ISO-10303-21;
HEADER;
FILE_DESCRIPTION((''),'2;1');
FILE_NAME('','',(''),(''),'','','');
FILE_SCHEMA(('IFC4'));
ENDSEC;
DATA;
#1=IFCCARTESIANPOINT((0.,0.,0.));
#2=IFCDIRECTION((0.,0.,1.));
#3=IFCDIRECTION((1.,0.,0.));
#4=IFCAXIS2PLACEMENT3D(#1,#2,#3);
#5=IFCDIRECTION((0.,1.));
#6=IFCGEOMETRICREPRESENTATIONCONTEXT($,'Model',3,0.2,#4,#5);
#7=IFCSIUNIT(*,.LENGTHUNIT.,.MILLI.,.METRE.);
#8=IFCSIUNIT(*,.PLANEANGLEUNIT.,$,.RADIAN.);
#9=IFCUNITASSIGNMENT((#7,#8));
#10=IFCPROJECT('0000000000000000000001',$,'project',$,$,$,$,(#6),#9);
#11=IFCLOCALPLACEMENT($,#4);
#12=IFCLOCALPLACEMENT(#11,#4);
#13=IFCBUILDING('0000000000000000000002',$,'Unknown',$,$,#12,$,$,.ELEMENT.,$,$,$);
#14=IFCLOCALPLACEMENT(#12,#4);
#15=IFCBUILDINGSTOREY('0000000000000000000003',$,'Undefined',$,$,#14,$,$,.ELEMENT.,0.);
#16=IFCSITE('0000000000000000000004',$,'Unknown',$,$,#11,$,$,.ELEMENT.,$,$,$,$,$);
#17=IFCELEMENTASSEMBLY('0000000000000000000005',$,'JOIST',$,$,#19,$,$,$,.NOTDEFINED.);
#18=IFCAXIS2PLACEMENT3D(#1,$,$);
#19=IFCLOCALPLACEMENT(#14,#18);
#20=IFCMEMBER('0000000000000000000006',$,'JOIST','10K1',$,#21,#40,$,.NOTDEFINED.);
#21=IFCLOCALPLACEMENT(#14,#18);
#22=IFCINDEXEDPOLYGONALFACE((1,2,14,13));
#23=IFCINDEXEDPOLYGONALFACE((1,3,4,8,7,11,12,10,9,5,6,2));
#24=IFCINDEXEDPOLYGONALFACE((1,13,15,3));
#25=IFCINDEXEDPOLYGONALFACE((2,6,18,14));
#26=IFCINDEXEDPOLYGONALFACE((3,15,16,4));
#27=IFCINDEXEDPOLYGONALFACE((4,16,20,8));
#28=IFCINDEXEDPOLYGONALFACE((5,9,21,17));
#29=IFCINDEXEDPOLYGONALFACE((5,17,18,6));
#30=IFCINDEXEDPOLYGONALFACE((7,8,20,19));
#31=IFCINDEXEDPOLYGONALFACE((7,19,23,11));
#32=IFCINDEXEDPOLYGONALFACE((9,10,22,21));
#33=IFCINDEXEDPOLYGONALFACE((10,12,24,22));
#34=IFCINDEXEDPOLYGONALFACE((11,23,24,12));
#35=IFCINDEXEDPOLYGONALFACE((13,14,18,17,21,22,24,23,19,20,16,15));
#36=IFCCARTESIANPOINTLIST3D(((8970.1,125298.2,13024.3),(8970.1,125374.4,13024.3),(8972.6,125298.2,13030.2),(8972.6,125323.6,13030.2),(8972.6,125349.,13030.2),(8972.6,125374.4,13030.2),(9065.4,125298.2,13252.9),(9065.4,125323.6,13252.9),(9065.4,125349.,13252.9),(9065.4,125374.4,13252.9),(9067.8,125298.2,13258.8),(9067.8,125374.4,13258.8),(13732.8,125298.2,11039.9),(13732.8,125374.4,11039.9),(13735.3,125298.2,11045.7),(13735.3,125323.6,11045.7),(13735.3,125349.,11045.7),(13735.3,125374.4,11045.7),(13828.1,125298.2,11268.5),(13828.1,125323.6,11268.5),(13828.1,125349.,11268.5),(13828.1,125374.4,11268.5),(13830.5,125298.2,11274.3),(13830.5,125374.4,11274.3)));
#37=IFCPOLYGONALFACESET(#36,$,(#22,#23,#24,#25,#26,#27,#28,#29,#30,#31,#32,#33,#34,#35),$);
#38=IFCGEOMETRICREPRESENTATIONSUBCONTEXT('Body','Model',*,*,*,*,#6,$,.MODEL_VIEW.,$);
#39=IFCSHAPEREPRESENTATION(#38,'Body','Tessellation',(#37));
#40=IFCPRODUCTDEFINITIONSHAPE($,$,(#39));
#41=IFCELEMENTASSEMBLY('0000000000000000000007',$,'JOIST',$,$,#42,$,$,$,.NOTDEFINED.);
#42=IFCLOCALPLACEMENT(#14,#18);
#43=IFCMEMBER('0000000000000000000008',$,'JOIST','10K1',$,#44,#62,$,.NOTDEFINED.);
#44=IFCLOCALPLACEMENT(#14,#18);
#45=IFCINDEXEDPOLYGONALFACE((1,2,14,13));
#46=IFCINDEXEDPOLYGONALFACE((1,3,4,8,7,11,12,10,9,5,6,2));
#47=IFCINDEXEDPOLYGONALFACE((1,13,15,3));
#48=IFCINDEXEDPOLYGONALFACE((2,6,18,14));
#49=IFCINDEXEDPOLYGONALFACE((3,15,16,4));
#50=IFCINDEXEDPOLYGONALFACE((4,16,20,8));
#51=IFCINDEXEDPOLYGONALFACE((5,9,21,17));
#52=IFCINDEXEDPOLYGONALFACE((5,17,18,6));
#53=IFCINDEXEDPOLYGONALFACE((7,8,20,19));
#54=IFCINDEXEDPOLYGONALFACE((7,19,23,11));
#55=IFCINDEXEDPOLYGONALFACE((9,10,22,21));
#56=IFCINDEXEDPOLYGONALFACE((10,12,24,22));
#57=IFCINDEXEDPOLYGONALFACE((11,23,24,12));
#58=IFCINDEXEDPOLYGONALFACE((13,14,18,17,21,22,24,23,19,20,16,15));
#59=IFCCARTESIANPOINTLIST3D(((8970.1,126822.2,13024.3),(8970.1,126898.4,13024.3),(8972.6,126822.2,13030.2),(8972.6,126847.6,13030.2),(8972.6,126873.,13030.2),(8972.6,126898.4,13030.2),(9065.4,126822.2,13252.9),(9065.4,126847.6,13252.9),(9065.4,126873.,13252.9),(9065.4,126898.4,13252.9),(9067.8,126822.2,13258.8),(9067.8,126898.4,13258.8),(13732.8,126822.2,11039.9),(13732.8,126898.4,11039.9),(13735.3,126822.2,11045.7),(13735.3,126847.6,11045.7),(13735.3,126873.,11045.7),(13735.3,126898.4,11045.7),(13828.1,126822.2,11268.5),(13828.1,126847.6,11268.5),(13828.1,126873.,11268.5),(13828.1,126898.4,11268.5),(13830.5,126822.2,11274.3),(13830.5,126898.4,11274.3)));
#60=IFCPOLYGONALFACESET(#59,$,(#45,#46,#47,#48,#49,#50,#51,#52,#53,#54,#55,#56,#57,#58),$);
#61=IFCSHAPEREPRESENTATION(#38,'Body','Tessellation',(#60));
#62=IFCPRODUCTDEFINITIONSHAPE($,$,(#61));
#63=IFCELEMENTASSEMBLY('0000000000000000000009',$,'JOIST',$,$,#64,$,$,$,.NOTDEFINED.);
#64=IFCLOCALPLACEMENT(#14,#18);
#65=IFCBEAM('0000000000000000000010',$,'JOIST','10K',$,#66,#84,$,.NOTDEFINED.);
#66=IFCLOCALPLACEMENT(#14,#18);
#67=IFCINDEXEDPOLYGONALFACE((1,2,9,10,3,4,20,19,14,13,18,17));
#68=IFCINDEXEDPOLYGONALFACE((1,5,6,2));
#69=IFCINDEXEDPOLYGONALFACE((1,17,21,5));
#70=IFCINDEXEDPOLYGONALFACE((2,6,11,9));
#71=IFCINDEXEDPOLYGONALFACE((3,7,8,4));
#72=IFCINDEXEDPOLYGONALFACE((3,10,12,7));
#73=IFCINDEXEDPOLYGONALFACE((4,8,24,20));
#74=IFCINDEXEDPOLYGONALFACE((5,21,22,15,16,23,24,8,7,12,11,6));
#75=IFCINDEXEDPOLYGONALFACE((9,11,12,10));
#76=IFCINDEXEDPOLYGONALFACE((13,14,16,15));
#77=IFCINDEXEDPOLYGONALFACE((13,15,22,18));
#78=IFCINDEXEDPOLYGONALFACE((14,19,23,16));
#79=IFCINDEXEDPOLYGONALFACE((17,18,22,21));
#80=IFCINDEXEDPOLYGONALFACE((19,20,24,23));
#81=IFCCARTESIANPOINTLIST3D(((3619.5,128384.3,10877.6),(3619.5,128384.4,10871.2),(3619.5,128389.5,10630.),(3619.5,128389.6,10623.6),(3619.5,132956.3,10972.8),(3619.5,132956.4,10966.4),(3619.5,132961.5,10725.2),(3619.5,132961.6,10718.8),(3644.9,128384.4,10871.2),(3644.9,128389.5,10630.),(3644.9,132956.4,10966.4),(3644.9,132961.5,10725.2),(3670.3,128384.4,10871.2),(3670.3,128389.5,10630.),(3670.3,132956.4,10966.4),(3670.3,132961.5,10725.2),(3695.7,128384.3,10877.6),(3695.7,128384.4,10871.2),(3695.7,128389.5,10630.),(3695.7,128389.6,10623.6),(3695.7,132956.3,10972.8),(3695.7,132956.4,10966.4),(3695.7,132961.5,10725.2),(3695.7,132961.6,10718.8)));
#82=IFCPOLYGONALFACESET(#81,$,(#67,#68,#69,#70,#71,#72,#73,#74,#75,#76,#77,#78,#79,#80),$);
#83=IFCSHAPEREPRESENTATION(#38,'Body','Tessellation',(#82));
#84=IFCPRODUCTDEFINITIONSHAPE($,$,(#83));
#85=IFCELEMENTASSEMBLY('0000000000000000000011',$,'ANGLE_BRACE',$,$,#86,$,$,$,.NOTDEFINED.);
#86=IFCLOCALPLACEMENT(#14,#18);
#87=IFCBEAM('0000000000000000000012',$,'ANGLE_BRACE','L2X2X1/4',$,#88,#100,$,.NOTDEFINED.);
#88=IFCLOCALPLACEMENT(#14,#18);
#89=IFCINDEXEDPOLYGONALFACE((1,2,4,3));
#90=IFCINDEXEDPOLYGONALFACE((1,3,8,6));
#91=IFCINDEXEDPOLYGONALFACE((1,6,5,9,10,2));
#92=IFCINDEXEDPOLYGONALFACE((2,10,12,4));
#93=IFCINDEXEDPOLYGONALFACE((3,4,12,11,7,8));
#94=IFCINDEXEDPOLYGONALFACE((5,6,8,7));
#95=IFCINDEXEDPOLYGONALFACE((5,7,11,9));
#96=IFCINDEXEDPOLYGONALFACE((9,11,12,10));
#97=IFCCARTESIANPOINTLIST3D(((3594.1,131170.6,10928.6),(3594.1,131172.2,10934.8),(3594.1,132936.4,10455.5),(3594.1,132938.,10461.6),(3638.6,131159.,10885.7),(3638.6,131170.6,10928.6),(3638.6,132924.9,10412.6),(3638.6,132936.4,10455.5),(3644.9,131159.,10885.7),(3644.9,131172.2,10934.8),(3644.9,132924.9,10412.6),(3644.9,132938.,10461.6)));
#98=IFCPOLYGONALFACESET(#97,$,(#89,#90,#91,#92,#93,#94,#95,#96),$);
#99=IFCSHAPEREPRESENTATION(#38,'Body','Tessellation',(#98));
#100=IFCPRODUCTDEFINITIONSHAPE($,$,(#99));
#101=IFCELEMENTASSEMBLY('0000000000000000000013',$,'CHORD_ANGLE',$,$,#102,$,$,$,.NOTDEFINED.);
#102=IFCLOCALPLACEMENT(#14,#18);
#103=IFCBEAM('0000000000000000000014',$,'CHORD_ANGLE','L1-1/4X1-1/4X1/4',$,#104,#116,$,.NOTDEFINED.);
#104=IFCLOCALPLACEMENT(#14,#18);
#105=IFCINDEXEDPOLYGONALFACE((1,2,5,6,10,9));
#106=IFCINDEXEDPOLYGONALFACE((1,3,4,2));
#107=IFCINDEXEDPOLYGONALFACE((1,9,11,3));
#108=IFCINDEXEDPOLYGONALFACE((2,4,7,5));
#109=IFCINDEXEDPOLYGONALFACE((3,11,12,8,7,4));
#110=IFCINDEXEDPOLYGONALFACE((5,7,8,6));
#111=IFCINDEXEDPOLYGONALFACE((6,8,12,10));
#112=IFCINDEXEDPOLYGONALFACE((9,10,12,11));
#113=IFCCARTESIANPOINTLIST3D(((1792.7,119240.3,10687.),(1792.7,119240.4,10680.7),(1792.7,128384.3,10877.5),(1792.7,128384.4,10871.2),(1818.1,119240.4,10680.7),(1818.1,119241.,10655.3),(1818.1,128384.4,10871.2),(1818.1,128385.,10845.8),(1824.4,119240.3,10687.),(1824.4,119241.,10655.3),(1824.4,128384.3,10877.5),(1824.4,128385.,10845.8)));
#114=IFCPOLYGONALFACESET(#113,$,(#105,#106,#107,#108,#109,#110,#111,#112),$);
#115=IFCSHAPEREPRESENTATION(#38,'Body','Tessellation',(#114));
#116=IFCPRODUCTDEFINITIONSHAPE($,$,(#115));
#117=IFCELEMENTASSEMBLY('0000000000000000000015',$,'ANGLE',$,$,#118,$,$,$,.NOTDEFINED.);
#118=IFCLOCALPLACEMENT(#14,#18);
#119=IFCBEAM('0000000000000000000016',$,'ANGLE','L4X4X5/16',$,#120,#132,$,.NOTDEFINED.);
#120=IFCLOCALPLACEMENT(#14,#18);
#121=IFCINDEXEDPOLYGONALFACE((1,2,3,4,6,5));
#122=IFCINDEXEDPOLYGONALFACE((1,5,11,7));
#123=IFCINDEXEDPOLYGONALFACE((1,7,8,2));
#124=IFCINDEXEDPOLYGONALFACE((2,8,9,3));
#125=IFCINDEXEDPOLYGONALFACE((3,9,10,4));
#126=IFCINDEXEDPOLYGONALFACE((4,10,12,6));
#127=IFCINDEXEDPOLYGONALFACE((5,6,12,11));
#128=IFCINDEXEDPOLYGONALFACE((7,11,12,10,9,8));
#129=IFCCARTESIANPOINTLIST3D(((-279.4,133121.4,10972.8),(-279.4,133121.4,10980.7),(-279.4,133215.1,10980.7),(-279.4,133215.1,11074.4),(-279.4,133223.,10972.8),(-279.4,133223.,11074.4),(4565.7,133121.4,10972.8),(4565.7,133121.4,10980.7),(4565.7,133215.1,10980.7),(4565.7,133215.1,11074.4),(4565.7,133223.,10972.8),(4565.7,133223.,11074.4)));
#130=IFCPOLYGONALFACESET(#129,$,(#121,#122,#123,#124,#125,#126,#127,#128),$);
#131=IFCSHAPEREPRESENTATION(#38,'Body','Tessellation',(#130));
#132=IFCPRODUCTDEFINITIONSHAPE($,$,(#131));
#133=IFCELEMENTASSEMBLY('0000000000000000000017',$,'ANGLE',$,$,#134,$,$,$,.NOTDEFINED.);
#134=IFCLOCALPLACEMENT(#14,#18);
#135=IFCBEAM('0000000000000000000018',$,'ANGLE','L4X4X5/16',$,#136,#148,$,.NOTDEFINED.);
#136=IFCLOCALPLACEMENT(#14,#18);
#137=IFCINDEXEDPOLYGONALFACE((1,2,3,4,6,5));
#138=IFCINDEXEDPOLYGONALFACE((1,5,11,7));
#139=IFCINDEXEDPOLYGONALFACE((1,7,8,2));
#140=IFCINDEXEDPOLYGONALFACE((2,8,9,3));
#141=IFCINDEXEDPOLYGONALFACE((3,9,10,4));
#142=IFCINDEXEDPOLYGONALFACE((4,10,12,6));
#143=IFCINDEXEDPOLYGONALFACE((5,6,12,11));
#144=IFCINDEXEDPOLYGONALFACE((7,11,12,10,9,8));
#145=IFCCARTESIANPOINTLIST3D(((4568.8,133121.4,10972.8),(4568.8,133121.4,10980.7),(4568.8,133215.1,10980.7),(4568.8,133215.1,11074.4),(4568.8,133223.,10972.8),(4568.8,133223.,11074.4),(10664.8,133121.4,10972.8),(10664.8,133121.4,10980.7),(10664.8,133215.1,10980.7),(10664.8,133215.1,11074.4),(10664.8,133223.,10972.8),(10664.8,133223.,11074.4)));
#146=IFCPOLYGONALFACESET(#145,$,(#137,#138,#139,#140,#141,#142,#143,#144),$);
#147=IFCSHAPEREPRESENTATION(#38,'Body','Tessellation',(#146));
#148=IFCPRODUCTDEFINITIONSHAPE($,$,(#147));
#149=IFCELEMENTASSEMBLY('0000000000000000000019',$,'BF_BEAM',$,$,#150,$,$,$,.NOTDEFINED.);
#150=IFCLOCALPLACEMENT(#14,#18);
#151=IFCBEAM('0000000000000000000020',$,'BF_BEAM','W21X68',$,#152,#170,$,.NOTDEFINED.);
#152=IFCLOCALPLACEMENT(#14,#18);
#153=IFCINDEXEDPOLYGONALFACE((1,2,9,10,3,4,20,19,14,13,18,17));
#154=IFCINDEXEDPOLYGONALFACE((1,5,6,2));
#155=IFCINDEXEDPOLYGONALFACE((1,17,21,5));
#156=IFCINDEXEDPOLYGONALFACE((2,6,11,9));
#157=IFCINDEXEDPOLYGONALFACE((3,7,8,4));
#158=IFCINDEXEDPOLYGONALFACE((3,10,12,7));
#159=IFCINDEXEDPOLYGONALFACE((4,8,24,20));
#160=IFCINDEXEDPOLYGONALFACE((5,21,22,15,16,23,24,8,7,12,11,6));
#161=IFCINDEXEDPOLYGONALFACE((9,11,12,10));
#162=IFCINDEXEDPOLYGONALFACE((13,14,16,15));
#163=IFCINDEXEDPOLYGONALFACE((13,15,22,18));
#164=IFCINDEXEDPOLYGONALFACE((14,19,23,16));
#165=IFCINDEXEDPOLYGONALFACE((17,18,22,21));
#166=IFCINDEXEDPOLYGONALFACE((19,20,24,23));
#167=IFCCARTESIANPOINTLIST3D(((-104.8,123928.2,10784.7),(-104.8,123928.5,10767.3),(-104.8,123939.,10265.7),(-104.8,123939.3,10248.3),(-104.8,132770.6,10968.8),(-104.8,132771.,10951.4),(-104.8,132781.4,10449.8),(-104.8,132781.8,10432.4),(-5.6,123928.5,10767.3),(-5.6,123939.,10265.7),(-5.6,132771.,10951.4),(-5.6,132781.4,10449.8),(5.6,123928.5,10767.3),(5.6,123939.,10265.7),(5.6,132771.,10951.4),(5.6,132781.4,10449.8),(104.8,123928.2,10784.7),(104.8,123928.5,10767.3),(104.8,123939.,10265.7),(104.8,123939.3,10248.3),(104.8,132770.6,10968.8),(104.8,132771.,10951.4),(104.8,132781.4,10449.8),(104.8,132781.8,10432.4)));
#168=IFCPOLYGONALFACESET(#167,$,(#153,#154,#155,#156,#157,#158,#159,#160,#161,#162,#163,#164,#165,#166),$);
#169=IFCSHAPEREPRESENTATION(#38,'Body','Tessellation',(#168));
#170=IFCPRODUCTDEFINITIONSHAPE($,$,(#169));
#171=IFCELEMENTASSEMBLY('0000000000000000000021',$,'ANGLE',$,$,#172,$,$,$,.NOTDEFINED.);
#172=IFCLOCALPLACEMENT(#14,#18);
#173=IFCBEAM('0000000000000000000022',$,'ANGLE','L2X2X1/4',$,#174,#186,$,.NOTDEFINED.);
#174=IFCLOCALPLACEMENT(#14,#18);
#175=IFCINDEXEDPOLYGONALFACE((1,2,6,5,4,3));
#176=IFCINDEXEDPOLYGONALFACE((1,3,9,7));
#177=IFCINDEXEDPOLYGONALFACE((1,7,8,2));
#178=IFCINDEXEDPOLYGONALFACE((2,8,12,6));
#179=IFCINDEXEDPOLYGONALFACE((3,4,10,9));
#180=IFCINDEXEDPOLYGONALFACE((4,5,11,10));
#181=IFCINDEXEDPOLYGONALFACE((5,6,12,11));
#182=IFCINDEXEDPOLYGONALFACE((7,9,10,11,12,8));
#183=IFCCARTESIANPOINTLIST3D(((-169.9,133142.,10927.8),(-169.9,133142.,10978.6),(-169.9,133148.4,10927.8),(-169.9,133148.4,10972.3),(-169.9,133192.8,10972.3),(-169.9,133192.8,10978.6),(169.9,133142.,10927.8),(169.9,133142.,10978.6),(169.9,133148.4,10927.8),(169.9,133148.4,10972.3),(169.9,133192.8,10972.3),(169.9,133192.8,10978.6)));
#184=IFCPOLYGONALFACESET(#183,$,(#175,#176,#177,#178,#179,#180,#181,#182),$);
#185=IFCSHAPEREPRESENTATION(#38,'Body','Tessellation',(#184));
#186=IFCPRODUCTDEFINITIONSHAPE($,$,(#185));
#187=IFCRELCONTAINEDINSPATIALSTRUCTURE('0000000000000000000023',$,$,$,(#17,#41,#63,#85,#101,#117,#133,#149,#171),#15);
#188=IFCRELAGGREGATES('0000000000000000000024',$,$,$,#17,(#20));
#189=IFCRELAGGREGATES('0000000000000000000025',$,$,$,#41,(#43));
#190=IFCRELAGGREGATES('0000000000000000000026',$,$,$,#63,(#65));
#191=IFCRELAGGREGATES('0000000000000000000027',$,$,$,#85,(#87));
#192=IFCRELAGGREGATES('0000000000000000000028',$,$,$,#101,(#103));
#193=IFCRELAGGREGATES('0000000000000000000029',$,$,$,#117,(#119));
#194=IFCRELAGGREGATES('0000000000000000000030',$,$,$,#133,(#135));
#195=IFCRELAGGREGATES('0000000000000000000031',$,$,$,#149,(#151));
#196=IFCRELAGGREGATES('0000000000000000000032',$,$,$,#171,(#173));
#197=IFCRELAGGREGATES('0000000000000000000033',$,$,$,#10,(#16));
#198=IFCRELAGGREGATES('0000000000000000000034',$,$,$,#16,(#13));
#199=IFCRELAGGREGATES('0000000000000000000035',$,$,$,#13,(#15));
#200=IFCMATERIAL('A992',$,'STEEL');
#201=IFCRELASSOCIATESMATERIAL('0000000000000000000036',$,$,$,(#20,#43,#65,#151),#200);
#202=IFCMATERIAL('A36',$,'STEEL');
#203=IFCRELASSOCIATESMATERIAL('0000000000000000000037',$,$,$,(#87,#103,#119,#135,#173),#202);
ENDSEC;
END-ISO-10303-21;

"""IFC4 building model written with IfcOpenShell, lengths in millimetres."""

from ifc_helpers import new_model, si_unit, direction, frame, origin_with_axes, place, context, subcontext, project, spatial, line, indexed_curve, outline, extrude, material, element, aggregate, save


model = new_model("IFC4")

# Units and contexts
model_context = context("Model", 3, precision=0.2, world=origin_with_axes(), true_north=direction((0.0, 1.0)))
body_context = subcontext(model_context, "Body", "Model", "MODEL_VIEW")
ifc_project = project(units=[si_unit("LENGTHUNIT", "METRE", prefix="MILLI"), si_unit("PLANEANGLEUNIT", "RADIAN")], contexts=[model_context])

# Site, building, storey
site_placement = place(None, origin_with_axes())
site = spatial("IfcSite", under=ifc_project, at=site_placement, Name="Unknown", CompositionType="ELEMENT")
building_placement = place(site_placement, origin_with_axes())
building = spatial("IfcBuilding", under=site, at=building_placement, Name="Unknown", CompositionType="ELEMENT")
storey_placement = place(building_placement, origin_with_axes())
storey = spatial("IfcBuildingStorey", under=building, at=storey_placement, Name="Undefined", CompositionType="ELEMENT", Elevation=0.0)

# Shared definitions
ifc_material_1 = material(Name="A992", Category="STEEL")
ifc_material_2 = material(Name="A36", Category="STEEL")

# Element assemblies, members
assembly_1_placement = place(storey_placement, frame((9019.0, 125336.3, 13141.6), z_axis=(0.0, -1.0, 0.0), x_axis=(0.923077, 0.000001, -0.384615)))
assembly_1 = element("IfcElementAssembly", 1, at=assembly_1_placement, inside=storey, Name="JOIST", PredefinedType="NOTDEFINED")
member_1_placement = place(assembly_1_placement, origin_with_axes())
member_1 = element("IfcMember", 2, at=member_1_placement, material=ifc_material_1, Name="JOIST", Description="10K1", PredefinedType="NOTDEFINED", context=body_context, shape_type="SolidModel", body=[
    extrude(outline(indexed_curve([(-38.1, -127.0), (38.1, -127.0), (38.1, -120.7), (12.7, -120.7), (12.7, 120.7), (38.1, 120.7), (38.1, 127.0), (-38.1, 127.0), (-38.1, 120.7), (-12.7, 120.7), (-12.7, -120.7), (-38.1, -120.7)], segments=[line(1, 2, 3, 4, 5, 6, 7, 8, 9, 10, 11, 12, 1)])), frame((0.0, 0.0, 0.0), z_axis=(-1.0, 0.0, 0.0), x_axis=(0.0, 0.0, 1.0)), (0.0, 0.0, -1.0), 5159.6),
])
aggregate(assembly_1, [member_1])
assembly_2_placement = place(storey_placement, frame((9019.0, 126860.3, 13141.6), z_axis=(0.0, -1.0, 0.0), x_axis=(0.923077, 0.000001, -0.384615)))
assembly_2 = element("IfcElementAssembly", 3, at=assembly_2_placement, inside=storey, Name="JOIST", PredefinedType="NOTDEFINED")
member_2_placement = place(assembly_2_placement, origin_with_axes())
member_2 = element("IfcMember", 4, at=member_2_placement, material=ifc_material_1, Name="JOIST", Description="10K1", PredefinedType="NOTDEFINED", context=body_context, shape_type="SolidModel", body=[
    extrude(outline(indexed_curve([(-38.1, -127.0), (38.1, -127.0), (38.1, -120.7), (12.7, -120.7), (12.7, 120.7), (38.1, 120.7), (38.1, 127.0), (-38.1, 127.0), (-38.1, 120.7), (-12.7, 120.7), (-12.7, -120.7), (-38.1, -120.7)], segments=[line(1, 2, 3, 4, 5, 6, 7, 8, 9, 10, 11, 12, 1)])), frame((0.0, 0.0, 0.0), z_axis=(-1.0, 0.0, 0.0), x_axis=(0.0, 0.0, 1.0)), (0.0, 0.0, -1.0), 5159.6),
])
aggregate(assembly_2, [member_2])

# Element assemblies, beams
assembly_3_placement = place(storey_placement, frame((3657.6, 128386.9, 10750.6), z_axis=(1.0, 0.0, 0.0), x_axis=(0.0, 0.999783, 0.020819)))
assembly_3 = element("IfcElementAssembly", 5, at=assembly_3_placement, inside=storey, Name="JOIST", PredefinedType="NOTDEFINED")
beam_1_placement = place(assembly_3_placement, origin_with_axes())
beam_1 = element("IfcBeam", 6, at=beam_1_placement, material=ifc_material_1, Name="JOIST", Description="10K", PredefinedType="NOTDEFINED", context=body_context, shape_type="SolidModel", body=[
    extrude(outline(indexed_curve([(-38.1, -127.0), (38.1, -127.0), (38.1, -120.7), (12.7, -120.7), (12.7, 120.7), (38.1, 120.7), (38.1, 127.0), (-38.1, 127.0), (-38.1, 120.7), (-12.7, 120.7), (-12.7, -120.7), (-38.1, -120.7)], segments=[line(1, 2, 3, 4, 5, 6, 7, 8, 9, 10, 11, 12, 1)])), frame((0.0, 0.0, 0.0), z_axis=(-1.0, 0.0, 0.0), x_axis=(0.0, 0.0, 1.0)), (0.0, 0.0, -1.0), 4573.0),
])
aggregate(assembly_3, [beam_1])
assembly_4_placement = place(storey_placement, frame((3619.5, 131165.6, 10910.2), z_axis=(-1.0, 0.0, 0.0), x_axis=(0.0, 0.965926, -0.258819)))
assembly_4 = element("IfcElementAssembly", 7, at=assembly_4_placement, inside=storey, Name="ANGLE_BRACE", PredefinedType="NOTDEFINED")
beam_2_placement = place(assembly_4_placement, origin_with_axes())
beam_2 = element("IfcBeam", 8, at=beam_2_placement, material=ifc_material_2, Name="ANGLE_BRACE", Description="L2X2X1/4", PredefinedType="NOTDEFINED", context=body_context, shape_type="SolidModel", body=[
    extrude(outline(indexed_curve([(-25.4, -25.4), (25.4, -25.4), (25.4, -19.1), (-19.1, -19.1), (-19.1, 25.4), (-25.4, 25.4)], segments=[line(1, 2, 3, 4, 5, 6, 1)])), frame((0.0, 0.0, 0.0), z_axis=(-1.0, 0.0, 0.0), x_axis=(0.0, 0.0, 1.0)), (0.0, 0.0, -1.0), 1828.1),
])
aggregate(assembly_4, [beam_2])
assembly_5_placement = place(storey_placement, frame((1808.5, 128384.6, 10861.7), z_axis=(0.0, 0.020829, -0.999783), x_axis=(0.0, -0.999783, -0.020831)))
assembly_5 = element("IfcElementAssembly", 9, at=assembly_5_placement, inside=storey, Name="CHORD_ANGLE", PredefinedType="NOTDEFINED")
beam_3_placement = place(assembly_5_placement, origin_with_axes())
beam_3 = element("IfcBeam", 10, at=beam_3_placement, material=ifc_material_2, Name="CHORD_ANGLE", Description="L1-1/4X1-1/4X1/4", PredefinedType="NOTDEFINED", context=body_context, shape_type="SolidModel", body=[
    extrude(outline(indexed_curve([(-15.9, -15.9), (15.9, -15.9), (15.9, -9.5), (-9.5, -9.5), (-9.5, 15.9), (-15.9, 15.9)], segments=[line(1, 2, 3, 4, 5, 6, 1)])), frame((0.0, 0.0, 0.0), z_axis=(-1.0, 0.0, 0.0), x_axis=(0.0, 0.0, 1.0)), (0.0, 0.0, -1.0), 9146.0),
])
aggregate(assembly_5, [beam_3])
assembly_6_placement = place(storey_placement, frame((-279.4, 133172.2, 11023.6), z_axis=(0.0, -1.0, 0.0), x_axis=(1.0, 0.0, 0.0)))
assembly_6 = element("IfcElementAssembly", 11, at=assembly_6_placement, inside=storey, Name="ANGLE", PredefinedType="NOTDEFINED")
beam_4_placement = place(assembly_6_placement, origin_with_axes())
beam_4 = element("IfcBeam", 12, at=beam_4_placement, material=ifc_material_2, Name="ANGLE", Description="L4X4X5/16", PredefinedType="NOTDEFINED", context=body_context, shape_type="SolidModel", body=[
    extrude(outline(indexed_curve([(-50.8, -50.8), (50.8, -50.8), (50.8, -42.9), (-42.9, -42.9), (-42.9, 50.8), (-50.8, 50.8)], segments=[line(1, 2, 3, 4, 5, 6, 1)])), frame((0.0, 0.0, 0.0), z_axis=(-1.0, 0.0, 0.0), x_axis=(0.0, 0.0, 1.0)), (0.0, 0.0, -1.0), 4845.1),
])
aggregate(assembly_6, [beam_4])
assembly_7_placement = place(storey_placement, frame((4568.8, 133172.2, 11023.6), z_axis=(0.0, -1.0, 0.0), x_axis=(1.0, 0.0, 0.0)))
assembly_7 = element("IfcElementAssembly", 13, at=assembly_7_placement, inside=storey, Name="ANGLE", PredefinedType="NOTDEFINED")
beam_5_placement = place(assembly_7_placement, origin_with_axes())
beam_5 = element("IfcBeam", 14, at=beam_5_placement, material=ifc_material_2, Name="ANGLE", Description="L4X4X5/16", PredefinedType="NOTDEFINED", context=body_context, shape_type="SolidModel", body=[
    extrude(outline(indexed_curve([(-50.8, -50.8), (50.8, -50.8), (50.8, -42.9), (-42.9, -42.9), (-42.9, 50.8), (-50.8, 50.8)], segments=[line(1, 2, 3, 4, 5, 6, 1)])), frame((0.0, 0.0, 0.0), z_axis=(-1.0, 0.0, 0.0), x_axis=(0.0, 0.0, 1.0)), (0.0, 0.0, -1.0), 6096.0),
])
aggregate(assembly_7, [beam_5])

# Element assembly, beam
assembly_8_placement = place(storey_placement, frame((0.0, 123933.7, 10516.5), z_axis=(1.0, 0.0, 0.0), x_axis=(0.0, 0.999783, 0.020819)))
assembly_8 = element("IfcElementAssembly", 15, at=assembly_8_placement, inside=storey, Name="BF_BEAM", PredefinedType="NOTDEFINED")
beam_6_placement = place(assembly_8_placement, origin_with_axes())
beam_6 = element("IfcBeam", 16, at=beam_6_placement, material=ifc_material_1, Name="BF_BEAM", Description="W21X68", PredefinedType="NOTDEFINED", context=body_context, shape_type="SolidModel", body=[
    extrude(outline(indexed_curve([(-104.8, -268.3), (104.8, -268.3), (104.8, -250.8), (5.6, -250.8), (5.6, 250.8), (104.8, 250.8), (104.8, 268.3), (-104.8, 268.3), (-104.8, 250.8), (-5.6, 250.8), (-5.6, -250.8), (-104.8, -250.8)], segments=[line(1, 2, 3, 4, 5, 6, 7, 8, 9, 10, 11, 12, 1)])), frame((0.0, 0.0, 0.0), z_axis=(-1.0, 0.0, 0.0), x_axis=(0.0, 0.0, 1.0)), (0.0, 0.0, -1.0), 8844.4),
])
aggregate(assembly_8, [beam_6])

# Element assembly, beam
assembly_9_placement = place(storey_placement, frame((169.9, 133167.4, 10953.2), z_axis=(0.0, 0.0, -1.0), x_axis=(-1.0, 0.0, 0.0)))
assembly_9 = element("IfcElementAssembly", 17, at=assembly_9_placement, inside=storey, Name="ANGLE", PredefinedType="NOTDEFINED")
beam_7_placement = place(assembly_9_placement, origin_with_axes())
beam_7 = element("IfcBeam", 18, at=beam_7_placement, material=ifc_material_2, Name="ANGLE", Description="L2X2X1/4", PredefinedType="NOTDEFINED", context=body_context, shape_type="SolidModel", body=[
    extrude(outline(indexed_curve([(-25.4, -25.4), (25.4, -25.4), (25.4, -19.1), (-19.1, -19.1), (-19.1, 25.4), (-25.4, 25.4)], segments=[line(1, 2, 3, 4, 5, 6, 1)])), frame((0.0, 0.0, 0.0), z_axis=(-1.0, 0.0, 0.0), x_axis=(0.0, 0.0, 1.0)), (0.0, 0.0, -1.0), 339.7),
])
aggregate(assembly_9, [beam_7])

save(model, "model.ifc")
